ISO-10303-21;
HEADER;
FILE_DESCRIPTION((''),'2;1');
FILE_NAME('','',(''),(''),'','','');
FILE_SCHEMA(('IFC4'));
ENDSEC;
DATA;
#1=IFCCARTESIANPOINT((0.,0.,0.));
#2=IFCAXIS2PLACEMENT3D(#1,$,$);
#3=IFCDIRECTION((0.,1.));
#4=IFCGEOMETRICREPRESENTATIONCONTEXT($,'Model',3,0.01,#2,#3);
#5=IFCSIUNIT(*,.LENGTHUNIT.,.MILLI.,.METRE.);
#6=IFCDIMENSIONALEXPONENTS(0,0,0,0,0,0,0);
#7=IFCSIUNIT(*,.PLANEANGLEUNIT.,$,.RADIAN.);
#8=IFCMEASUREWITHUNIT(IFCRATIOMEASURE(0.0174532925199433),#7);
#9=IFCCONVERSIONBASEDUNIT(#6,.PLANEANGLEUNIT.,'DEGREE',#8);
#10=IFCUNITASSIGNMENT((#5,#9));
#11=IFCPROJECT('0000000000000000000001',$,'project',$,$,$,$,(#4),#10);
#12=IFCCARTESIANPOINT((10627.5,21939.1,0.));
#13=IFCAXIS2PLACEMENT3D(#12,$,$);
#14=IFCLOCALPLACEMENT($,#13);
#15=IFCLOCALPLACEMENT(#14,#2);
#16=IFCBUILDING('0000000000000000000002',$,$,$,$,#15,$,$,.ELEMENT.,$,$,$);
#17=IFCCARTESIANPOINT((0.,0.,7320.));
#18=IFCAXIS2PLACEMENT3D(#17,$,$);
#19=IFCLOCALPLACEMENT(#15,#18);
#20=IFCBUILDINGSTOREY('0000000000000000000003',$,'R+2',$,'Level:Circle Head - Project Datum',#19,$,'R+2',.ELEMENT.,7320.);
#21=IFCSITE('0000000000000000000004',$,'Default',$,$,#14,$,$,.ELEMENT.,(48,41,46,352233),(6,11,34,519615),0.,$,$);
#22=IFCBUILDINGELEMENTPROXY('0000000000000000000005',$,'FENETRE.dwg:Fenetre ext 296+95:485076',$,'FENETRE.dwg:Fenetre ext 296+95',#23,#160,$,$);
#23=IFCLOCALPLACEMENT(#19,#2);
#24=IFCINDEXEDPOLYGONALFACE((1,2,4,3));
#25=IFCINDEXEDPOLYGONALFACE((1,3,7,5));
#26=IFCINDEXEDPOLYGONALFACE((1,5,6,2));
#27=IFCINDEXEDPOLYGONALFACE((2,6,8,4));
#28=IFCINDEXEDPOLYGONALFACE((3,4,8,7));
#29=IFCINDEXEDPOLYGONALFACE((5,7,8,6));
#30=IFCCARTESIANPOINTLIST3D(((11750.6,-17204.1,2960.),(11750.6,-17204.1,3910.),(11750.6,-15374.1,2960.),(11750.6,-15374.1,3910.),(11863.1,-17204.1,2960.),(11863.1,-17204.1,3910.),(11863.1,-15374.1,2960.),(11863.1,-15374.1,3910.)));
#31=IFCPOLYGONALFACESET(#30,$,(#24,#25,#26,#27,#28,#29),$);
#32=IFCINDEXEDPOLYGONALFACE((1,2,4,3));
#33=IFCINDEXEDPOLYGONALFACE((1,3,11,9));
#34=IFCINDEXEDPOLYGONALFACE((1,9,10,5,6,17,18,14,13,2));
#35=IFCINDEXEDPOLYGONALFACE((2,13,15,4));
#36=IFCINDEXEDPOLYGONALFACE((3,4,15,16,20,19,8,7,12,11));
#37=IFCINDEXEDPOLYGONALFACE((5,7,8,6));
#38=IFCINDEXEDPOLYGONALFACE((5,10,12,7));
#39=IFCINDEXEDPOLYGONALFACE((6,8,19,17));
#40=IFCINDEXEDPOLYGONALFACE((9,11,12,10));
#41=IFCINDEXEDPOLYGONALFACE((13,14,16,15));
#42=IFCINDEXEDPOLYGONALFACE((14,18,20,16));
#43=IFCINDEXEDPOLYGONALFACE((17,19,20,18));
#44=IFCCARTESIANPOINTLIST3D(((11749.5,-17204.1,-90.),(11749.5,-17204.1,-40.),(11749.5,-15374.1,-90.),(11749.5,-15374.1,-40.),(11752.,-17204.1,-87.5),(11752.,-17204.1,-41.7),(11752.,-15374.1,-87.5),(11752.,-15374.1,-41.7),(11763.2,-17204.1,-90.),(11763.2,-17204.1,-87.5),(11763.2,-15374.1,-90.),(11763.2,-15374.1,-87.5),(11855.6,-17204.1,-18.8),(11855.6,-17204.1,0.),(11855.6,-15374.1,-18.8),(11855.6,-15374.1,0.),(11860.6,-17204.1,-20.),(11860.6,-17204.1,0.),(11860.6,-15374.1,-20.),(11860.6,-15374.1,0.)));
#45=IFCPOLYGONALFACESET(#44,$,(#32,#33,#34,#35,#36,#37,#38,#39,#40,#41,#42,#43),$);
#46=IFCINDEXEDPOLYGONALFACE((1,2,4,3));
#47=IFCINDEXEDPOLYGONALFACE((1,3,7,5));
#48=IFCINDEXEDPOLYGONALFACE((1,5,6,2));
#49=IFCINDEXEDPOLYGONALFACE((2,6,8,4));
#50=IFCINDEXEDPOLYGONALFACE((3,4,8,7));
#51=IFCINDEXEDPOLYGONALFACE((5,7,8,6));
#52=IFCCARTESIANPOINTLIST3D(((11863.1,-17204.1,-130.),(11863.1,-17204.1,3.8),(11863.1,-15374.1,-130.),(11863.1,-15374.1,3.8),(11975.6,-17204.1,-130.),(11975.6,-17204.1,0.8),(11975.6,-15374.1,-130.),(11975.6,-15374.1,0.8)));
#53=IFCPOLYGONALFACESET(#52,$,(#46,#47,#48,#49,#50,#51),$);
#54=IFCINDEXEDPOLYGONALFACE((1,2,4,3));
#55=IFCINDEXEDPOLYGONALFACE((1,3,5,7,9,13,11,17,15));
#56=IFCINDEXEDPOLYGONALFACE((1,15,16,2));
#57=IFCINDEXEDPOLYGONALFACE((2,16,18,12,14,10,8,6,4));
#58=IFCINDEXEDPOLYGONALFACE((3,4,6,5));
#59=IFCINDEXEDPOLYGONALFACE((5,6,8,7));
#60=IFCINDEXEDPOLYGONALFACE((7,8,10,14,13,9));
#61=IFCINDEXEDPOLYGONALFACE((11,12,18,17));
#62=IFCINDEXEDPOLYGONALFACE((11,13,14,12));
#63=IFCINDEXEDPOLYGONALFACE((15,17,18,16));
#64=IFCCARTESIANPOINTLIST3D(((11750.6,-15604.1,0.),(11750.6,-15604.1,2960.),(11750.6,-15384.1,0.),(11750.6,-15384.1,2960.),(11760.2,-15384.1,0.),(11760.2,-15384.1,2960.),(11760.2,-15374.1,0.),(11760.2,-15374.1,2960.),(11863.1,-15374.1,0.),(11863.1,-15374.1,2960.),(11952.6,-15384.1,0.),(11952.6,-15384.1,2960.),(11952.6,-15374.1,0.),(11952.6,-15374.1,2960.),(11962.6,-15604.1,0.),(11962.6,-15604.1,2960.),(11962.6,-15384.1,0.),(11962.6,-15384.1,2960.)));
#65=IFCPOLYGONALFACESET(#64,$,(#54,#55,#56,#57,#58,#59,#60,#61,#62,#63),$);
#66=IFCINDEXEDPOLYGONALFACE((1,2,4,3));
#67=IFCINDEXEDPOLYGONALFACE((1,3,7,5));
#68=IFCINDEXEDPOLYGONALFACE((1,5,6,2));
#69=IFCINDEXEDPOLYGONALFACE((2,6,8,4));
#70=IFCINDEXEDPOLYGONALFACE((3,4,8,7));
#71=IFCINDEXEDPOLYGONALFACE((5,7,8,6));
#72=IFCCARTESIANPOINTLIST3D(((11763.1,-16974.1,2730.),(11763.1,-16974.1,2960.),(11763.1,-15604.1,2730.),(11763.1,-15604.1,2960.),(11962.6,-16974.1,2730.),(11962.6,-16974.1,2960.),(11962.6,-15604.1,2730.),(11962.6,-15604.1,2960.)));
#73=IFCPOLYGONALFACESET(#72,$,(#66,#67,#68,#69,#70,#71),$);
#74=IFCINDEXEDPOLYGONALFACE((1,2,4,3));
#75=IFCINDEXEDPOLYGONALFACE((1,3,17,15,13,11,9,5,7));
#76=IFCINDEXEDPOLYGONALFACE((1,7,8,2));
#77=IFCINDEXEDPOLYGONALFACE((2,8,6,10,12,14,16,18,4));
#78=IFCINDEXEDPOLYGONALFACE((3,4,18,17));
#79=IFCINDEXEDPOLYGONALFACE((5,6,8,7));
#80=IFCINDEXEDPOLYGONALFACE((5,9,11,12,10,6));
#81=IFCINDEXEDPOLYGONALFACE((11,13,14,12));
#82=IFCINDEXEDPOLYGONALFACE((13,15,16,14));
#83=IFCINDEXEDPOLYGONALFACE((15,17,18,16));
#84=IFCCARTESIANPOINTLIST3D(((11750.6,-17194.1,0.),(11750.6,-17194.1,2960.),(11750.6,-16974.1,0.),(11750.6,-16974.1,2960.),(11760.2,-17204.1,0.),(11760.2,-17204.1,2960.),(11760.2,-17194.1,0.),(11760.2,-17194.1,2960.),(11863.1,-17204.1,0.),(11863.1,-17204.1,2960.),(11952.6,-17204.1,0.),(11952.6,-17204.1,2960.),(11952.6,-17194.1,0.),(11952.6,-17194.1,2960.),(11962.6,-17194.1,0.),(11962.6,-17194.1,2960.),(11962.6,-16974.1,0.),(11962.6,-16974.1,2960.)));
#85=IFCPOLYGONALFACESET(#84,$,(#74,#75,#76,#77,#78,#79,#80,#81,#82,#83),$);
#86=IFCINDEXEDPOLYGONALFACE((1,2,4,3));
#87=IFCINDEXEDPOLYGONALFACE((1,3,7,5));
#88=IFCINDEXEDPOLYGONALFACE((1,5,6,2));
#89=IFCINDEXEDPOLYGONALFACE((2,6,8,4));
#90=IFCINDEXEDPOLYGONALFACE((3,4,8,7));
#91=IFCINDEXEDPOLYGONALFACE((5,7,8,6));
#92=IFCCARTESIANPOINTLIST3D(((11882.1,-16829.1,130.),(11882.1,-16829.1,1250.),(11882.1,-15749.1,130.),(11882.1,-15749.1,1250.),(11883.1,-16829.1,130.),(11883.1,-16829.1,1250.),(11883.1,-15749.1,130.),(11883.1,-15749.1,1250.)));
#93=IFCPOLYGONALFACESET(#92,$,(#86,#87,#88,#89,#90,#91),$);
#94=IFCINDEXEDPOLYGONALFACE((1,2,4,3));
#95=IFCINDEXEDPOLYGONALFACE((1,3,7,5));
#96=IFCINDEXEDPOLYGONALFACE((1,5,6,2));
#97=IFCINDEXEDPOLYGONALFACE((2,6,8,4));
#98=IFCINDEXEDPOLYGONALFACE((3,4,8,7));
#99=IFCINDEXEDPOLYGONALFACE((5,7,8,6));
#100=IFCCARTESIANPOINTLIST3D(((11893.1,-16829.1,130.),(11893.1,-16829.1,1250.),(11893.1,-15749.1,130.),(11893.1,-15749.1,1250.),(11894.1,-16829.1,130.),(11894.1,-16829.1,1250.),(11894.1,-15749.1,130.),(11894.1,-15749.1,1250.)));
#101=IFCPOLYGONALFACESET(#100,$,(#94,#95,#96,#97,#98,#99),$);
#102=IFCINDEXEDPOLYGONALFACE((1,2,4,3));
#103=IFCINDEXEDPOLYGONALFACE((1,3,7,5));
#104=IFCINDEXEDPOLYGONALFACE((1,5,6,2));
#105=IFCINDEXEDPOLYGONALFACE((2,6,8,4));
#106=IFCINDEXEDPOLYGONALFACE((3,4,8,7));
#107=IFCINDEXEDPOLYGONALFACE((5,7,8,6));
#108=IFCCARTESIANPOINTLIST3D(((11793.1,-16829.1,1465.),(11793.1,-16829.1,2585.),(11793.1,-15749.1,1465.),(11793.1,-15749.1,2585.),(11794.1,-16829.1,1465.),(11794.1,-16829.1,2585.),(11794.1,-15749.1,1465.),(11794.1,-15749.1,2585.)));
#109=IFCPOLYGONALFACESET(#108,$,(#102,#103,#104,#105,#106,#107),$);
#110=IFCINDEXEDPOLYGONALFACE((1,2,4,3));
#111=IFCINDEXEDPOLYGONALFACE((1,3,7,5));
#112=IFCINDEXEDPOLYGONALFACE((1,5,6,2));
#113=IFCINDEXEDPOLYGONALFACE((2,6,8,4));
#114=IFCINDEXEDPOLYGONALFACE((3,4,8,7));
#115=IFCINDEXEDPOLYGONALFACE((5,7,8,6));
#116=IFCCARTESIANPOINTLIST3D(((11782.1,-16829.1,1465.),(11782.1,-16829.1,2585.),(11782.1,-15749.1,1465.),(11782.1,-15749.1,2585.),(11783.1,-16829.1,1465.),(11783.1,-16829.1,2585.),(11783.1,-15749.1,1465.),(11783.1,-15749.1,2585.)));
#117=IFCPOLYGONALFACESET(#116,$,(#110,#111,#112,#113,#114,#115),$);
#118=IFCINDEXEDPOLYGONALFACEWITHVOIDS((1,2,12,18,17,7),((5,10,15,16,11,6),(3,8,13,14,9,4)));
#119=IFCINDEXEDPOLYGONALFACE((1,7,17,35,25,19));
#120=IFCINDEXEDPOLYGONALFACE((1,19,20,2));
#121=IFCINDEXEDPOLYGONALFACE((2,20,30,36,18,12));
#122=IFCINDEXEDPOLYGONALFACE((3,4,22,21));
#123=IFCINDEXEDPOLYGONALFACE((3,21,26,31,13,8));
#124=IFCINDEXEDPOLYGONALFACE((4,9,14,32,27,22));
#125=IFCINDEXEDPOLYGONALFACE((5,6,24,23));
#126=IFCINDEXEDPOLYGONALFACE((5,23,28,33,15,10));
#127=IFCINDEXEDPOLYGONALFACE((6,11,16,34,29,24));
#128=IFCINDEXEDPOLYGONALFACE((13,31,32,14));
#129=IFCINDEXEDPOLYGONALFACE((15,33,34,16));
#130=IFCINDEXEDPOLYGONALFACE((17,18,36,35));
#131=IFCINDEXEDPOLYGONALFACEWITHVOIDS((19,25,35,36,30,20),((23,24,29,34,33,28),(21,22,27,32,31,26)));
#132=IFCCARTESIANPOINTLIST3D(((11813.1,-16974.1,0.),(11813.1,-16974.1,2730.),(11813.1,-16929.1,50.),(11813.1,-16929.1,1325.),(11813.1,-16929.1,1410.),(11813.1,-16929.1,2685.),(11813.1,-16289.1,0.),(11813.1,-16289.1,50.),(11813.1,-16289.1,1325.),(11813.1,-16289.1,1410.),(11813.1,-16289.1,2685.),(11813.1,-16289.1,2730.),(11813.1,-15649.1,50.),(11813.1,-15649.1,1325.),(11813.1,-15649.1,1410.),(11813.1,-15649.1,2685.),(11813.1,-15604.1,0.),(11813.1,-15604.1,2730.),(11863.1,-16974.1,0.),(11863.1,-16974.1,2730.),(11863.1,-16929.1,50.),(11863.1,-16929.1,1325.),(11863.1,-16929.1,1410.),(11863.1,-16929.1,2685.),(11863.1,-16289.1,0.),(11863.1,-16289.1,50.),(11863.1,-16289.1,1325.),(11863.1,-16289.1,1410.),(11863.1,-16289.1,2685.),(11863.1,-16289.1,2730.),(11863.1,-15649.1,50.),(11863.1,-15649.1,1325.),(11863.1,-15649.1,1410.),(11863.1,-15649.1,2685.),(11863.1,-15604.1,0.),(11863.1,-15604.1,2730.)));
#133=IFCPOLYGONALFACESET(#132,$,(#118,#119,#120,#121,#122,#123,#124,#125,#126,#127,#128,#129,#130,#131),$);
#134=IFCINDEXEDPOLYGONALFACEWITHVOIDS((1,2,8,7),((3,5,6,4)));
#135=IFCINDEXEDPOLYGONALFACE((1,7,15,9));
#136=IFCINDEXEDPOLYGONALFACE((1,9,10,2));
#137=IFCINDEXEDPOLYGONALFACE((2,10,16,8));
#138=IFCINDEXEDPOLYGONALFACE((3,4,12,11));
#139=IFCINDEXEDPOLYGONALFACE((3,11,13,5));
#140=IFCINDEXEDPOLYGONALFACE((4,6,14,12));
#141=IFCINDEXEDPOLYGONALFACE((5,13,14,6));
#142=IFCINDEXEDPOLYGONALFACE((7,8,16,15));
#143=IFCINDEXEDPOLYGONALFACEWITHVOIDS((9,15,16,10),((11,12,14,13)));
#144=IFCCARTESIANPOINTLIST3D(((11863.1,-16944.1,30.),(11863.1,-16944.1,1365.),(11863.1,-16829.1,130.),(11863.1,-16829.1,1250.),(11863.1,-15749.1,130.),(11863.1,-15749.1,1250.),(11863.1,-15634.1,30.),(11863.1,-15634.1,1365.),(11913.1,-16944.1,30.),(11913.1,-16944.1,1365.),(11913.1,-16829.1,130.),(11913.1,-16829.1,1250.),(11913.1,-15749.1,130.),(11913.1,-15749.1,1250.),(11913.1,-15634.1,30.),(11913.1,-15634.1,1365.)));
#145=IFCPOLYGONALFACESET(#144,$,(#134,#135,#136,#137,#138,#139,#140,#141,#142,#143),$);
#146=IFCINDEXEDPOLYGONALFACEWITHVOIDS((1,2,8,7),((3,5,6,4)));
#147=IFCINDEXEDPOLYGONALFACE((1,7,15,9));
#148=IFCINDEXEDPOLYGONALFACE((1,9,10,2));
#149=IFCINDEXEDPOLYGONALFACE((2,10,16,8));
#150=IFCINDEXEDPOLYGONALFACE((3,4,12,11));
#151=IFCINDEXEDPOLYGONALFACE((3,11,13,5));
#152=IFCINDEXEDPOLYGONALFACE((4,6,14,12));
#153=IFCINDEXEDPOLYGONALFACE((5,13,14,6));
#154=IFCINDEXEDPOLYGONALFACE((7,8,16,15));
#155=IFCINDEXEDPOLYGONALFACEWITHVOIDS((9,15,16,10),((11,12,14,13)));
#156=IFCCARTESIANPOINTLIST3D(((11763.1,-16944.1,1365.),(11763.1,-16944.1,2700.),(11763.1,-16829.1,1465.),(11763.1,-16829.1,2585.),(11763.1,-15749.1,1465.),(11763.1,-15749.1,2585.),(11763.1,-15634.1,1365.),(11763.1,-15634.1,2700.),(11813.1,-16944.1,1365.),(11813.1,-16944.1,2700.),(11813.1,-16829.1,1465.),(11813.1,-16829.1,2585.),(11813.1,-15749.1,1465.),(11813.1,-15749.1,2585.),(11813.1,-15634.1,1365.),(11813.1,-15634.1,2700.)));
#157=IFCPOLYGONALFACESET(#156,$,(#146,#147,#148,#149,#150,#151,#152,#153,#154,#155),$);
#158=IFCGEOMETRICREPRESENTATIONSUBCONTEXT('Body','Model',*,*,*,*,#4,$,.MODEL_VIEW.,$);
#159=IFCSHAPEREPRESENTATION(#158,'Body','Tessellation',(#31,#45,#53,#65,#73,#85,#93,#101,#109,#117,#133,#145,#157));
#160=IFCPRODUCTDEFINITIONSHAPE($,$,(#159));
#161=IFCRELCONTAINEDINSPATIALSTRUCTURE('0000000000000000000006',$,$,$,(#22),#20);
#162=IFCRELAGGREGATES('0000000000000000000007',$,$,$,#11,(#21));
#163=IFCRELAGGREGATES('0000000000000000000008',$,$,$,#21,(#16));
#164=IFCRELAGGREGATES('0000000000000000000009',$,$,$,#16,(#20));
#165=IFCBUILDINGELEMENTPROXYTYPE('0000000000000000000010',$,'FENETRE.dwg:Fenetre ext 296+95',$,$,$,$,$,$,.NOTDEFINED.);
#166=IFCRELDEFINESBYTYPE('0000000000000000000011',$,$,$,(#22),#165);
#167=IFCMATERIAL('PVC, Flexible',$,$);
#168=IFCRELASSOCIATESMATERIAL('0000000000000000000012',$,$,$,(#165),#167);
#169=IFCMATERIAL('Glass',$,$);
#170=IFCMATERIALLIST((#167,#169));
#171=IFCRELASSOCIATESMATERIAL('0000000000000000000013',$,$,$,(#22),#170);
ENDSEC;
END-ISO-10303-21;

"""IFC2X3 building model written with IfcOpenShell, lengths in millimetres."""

from ifc_helpers import new_model, entity, si_unit, converted_unit, direction, frame, frame_2d, origin, origin_2d_with_axis, place, context, subcontext, project, spatial, polyline, rectangle, outline, extrude, source, transform, mapped, material, material_list, type_object, type_shapes, element, save


model = new_model("IFC2X3")

# Units and contexts
model_context = context("Model", 3, precision=0.01, world=origin(), true_north=direction((0.0, 1.0)))
body_context = subcontext(model_context, "Body", "Model", "MODEL_VIEW")
ifc_project = project(units=[si_unit("LENGTHUNIT", "METRE", prefix="MILLI"), converted_unit("PLANEANGLEUNIT", "DEGREE", entity("IfcRatioMeasure", 0.0174532925199433), si_unit("PLANEANGLEUNIT", "RADIAN"), dimensions=[0, 0, 0, 0, 0, 0, 0])], contexts=[model_context])

# Site, building, storey
site_placement = place(None, frame((10627.5, 21939.1, 0.0)))
site = spatial("IfcSite", under=ifc_project, at=site_placement, Name="Default", CompositionType="ELEMENT", RefLatitude=(48, 41, 46, 352233), RefLongitude=(6, 11, 34, 519615), RefElevation=0.0)
building_placement = place(site_placement, origin())
building = spatial("IfcBuilding", under=site, at=building_placement, CompositionType="ELEMENT")
storey_placement = place(building_placement, frame((0.0, 0.0, 7320.0)))
storey = spatial("IfcBuildingStorey", under=building, at=storey_placement, Name="R+2", ObjectType="Level:Circle Head - Project Datum", LongName="R+2", CompositionType="ELEMENT", Elevation=7320.0)

# Building element proxy
ifc_material_1 = material(Name="PVC, Flexible")
ifc_material_2 = material(Name="Glass")
building_element_proxy_type_1 = type_object("IfcBuildingElementProxyType", Name="FENETRE.dwg:Fenetre ext 296+95", PredefinedType="NOTDEFINED", material=ifc_material_1)
shared_shape_1 = source(origin(), body_context, "Body", "SweptSolid", [
    extrude(rectangle(XDim=1830.0, YDim=112.5, at=origin_2d_with_axis()), frame((-10.4, 56.3, 2960.0), z_axis=(0.0, 0.0, 1.0), x_axis=(-1.0, 0.0, 0.0)), (0.0, 0.0, 1.0), 950.0),
    extrude(outline(polyline([(-68.6, -14.4), (-72.5, -34.0), (-67.6, -35.0), (-63.9, -16.6), (44.3, -16.6), (54.1, 32.5), (40.6, 35.2), (40.1, 32.7), (51.2, 30.5), (42.2, -14.4), (-68.6, -14.4)])), frame((-925.4, 66.9, -47.5), z_axis=(-1.0, 0.0, 0.0), x_axis=(0.0, 0.980599, -0.196027)), (0.0, 0.0, -1.0), 1830.0),
    extrude(outline(polyline([(-64.7, -56.3), (66.2, -56.3), (66.2, 56.3), (-67.7, 56.3), (-64.7, -56.3)])), frame((-925.4, -56.3, -63.8), z_axis=(1.0, 0.0, 0.0), x_axis=(0.0, 0.0, -1.0)), (0.0, 0.0, 1.0), 1830.0),
    extrude(outline(polyline([(-55.6, 97.0), (-55.6, -5.9), (-55.6, -95.4), (-45.6, -95.4), (-45.6, -105.4), (174.4, -105.4), (174.4, 106.6), (-45.6, 106.6), (-45.6, 97.0), (-55.6, 97.0)])), frame((849.0, 5.9, 0.0), z_axis=(0.0, 0.0, -1.0), x_axis=(-1.0, 0.0, 0.0)), (0.0, 0.0, -1.0), 2960.0),
    extrude(rectangle(XDim=199.5, YDim=1370.0, at=origin_2d_with_axis()), frame((-10.4, 0.3, 2730.0), z_axis=(0.0, 0.0, 1.0), x_axis=(0.0, 1.0, 0.0)), (0.0, 0.0, 1.0), 230.0),
    extrude(outline(polyline([(-97.0, -55.6), (5.9, -55.6), (95.4, -55.6), (95.4, -45.6), (105.4, -45.6), (105.4, 174.4), (-106.6, 174.4), (-106.6, -45.6), (-97.0, -45.6), (-97.0, -55.6)])), frame((-869.9, 5.9, 0.0), z_axis=(0.0, 0.0, 1.0), x_axis=(0.0, -1.0, 0.0)), (0.0, 0.0, 1.0), 2960.0),
    extrude(rectangle(XDim=1.0, YDim=1080.0, at=origin_2d_with_axis()), frame((-10.4, -19.5, 130.0), z_axis=(0.0, 0.0, 1.0), x_axis=(0.0, 1.0, 0.0)), (0.0, 0.0, 1.0), 1120.0),
    extrude(rectangle(XDim=1.0, YDim=1080.0, at=frame_2d((0.0, 0.0), x_axis=(1.0, 0.0))), frame((-10.4, -30.5, 130.0), z_axis=(0.0, 0.0, 1.0), x_axis=(0.0, 1.0, 0.0)), (0.0, 0.0, 1.0), 1120.0),
    extrude(rectangle(XDim=1.0, YDim=1080.0, at=frame_2d((0.0, 0.0), x_axis=(1.0, 0.0))), frame((-10.4, 69.5, 1465.0), z_axis=(0.0, 0.0, 1.0), x_axis=(0.0, 1.0, 0.0)), (0.0, 0.0, 1.0), 1120.0),
    extrude(rectangle(XDim=1.0, YDim=1080.0, at=frame_2d((0.0, 0.0), x_axis=(1.0, 0.0))), frame((-10.4, 80.5, 1465.0), z_axis=(0.0, 0.0, 1.0), x_axis=(0.0, 1.0, 0.0)), (0.0, 0.0, 1.0), 1120.0),
    extrude(outline(polyline([(-685.0, -1365.0), (0.0, -1365.0), (685.0, -1365.0), (685.0, 1365.0), (0.0, 1365.0), (-685.0, 1365.0), (-685.0, -1365.0)]), holes=[polyline([(-640.0, -1320.0), (-640.0, -45.0), (0.0, -45.0), (640.0, -45.0), (640.0, -1320.0), (0.0, -1320.0), (-640.0, -1320.0)]), polyline([(-640.0, 40.0), (-640.0, 1315.0), (0.0, 1315.0), (640.0, 1315.0), (640.0, 40.0), (0.0, 40.0), (-640.0, 40.0)])]), frame((-10.4, 0.0, 1365.0), z_axis=(0.0, 1.0, 0.0), x_axis=(1.0, 0.0, 0.0)), (0.0, 0.0, 1.0), 50.0),
    extrude(outline(polyline([(-655.0, -667.5), (655.0, -667.5), (655.0, 667.5), (-655.0, 667.5), (-655.0, -667.5)]), holes=[polyline([(-540.0, 552.5), (540.0, 552.5), (540.0, -567.5), (-540.0, -567.5), (-540.0, 552.5)])]), frame((-10.4, -50.0, 697.5), z_axis=(0.0, 1.0, 0.0), x_axis=(-1.0, 0.0, 0.0)), (0.0, 0.0, 1.0), 50.0),
    extrude(outline(polyline([(-655.0, -667.5), (655.0, -667.5), (655.0, 667.5), (-655.0, 667.5), (-655.0, -667.5)]), holes=[polyline([(-540.0, 552.5), (540.0, 552.5), (540.0, -567.5), (-540.0, -567.5), (-540.0, 552.5)])]), frame((-10.4, 50.0, 2032.5), z_axis=(0.0, 1.0, 0.0), x_axis=(-1.0, 0.0, 0.0)), (0.0, 0.0, 1.0), 50.0),
])
type_shapes(building_element_proxy_type_1, [shared_shape_1])
ifc_material_list_1 = material_list([ifc_material_1, ifc_material_2])
proxy_1_placement = place(storey_placement, frame((11863.1, -16278.7, 0.0), z_axis=(0.0, 0.0, 1.0), x_axis=(0.0, 1.0, 0.0)))
element("IfcBuildingElementProxy", 1, at=proxy_1_placement, inside=storey, type_object=building_element_proxy_type_1, material=ifc_material_list_1, Name="FENETRE.dwg:Fenetre ext 296+95:485076", ObjectType="FENETRE.dwg:Fenetre ext 296+95", context=body_context, shape_type="MappedRepresentation", body=[
    mapped(shared_shape_1, transform((0.0, 0.0, 0.0), scale=1.0)),
])

save(model, "model.ifc")
